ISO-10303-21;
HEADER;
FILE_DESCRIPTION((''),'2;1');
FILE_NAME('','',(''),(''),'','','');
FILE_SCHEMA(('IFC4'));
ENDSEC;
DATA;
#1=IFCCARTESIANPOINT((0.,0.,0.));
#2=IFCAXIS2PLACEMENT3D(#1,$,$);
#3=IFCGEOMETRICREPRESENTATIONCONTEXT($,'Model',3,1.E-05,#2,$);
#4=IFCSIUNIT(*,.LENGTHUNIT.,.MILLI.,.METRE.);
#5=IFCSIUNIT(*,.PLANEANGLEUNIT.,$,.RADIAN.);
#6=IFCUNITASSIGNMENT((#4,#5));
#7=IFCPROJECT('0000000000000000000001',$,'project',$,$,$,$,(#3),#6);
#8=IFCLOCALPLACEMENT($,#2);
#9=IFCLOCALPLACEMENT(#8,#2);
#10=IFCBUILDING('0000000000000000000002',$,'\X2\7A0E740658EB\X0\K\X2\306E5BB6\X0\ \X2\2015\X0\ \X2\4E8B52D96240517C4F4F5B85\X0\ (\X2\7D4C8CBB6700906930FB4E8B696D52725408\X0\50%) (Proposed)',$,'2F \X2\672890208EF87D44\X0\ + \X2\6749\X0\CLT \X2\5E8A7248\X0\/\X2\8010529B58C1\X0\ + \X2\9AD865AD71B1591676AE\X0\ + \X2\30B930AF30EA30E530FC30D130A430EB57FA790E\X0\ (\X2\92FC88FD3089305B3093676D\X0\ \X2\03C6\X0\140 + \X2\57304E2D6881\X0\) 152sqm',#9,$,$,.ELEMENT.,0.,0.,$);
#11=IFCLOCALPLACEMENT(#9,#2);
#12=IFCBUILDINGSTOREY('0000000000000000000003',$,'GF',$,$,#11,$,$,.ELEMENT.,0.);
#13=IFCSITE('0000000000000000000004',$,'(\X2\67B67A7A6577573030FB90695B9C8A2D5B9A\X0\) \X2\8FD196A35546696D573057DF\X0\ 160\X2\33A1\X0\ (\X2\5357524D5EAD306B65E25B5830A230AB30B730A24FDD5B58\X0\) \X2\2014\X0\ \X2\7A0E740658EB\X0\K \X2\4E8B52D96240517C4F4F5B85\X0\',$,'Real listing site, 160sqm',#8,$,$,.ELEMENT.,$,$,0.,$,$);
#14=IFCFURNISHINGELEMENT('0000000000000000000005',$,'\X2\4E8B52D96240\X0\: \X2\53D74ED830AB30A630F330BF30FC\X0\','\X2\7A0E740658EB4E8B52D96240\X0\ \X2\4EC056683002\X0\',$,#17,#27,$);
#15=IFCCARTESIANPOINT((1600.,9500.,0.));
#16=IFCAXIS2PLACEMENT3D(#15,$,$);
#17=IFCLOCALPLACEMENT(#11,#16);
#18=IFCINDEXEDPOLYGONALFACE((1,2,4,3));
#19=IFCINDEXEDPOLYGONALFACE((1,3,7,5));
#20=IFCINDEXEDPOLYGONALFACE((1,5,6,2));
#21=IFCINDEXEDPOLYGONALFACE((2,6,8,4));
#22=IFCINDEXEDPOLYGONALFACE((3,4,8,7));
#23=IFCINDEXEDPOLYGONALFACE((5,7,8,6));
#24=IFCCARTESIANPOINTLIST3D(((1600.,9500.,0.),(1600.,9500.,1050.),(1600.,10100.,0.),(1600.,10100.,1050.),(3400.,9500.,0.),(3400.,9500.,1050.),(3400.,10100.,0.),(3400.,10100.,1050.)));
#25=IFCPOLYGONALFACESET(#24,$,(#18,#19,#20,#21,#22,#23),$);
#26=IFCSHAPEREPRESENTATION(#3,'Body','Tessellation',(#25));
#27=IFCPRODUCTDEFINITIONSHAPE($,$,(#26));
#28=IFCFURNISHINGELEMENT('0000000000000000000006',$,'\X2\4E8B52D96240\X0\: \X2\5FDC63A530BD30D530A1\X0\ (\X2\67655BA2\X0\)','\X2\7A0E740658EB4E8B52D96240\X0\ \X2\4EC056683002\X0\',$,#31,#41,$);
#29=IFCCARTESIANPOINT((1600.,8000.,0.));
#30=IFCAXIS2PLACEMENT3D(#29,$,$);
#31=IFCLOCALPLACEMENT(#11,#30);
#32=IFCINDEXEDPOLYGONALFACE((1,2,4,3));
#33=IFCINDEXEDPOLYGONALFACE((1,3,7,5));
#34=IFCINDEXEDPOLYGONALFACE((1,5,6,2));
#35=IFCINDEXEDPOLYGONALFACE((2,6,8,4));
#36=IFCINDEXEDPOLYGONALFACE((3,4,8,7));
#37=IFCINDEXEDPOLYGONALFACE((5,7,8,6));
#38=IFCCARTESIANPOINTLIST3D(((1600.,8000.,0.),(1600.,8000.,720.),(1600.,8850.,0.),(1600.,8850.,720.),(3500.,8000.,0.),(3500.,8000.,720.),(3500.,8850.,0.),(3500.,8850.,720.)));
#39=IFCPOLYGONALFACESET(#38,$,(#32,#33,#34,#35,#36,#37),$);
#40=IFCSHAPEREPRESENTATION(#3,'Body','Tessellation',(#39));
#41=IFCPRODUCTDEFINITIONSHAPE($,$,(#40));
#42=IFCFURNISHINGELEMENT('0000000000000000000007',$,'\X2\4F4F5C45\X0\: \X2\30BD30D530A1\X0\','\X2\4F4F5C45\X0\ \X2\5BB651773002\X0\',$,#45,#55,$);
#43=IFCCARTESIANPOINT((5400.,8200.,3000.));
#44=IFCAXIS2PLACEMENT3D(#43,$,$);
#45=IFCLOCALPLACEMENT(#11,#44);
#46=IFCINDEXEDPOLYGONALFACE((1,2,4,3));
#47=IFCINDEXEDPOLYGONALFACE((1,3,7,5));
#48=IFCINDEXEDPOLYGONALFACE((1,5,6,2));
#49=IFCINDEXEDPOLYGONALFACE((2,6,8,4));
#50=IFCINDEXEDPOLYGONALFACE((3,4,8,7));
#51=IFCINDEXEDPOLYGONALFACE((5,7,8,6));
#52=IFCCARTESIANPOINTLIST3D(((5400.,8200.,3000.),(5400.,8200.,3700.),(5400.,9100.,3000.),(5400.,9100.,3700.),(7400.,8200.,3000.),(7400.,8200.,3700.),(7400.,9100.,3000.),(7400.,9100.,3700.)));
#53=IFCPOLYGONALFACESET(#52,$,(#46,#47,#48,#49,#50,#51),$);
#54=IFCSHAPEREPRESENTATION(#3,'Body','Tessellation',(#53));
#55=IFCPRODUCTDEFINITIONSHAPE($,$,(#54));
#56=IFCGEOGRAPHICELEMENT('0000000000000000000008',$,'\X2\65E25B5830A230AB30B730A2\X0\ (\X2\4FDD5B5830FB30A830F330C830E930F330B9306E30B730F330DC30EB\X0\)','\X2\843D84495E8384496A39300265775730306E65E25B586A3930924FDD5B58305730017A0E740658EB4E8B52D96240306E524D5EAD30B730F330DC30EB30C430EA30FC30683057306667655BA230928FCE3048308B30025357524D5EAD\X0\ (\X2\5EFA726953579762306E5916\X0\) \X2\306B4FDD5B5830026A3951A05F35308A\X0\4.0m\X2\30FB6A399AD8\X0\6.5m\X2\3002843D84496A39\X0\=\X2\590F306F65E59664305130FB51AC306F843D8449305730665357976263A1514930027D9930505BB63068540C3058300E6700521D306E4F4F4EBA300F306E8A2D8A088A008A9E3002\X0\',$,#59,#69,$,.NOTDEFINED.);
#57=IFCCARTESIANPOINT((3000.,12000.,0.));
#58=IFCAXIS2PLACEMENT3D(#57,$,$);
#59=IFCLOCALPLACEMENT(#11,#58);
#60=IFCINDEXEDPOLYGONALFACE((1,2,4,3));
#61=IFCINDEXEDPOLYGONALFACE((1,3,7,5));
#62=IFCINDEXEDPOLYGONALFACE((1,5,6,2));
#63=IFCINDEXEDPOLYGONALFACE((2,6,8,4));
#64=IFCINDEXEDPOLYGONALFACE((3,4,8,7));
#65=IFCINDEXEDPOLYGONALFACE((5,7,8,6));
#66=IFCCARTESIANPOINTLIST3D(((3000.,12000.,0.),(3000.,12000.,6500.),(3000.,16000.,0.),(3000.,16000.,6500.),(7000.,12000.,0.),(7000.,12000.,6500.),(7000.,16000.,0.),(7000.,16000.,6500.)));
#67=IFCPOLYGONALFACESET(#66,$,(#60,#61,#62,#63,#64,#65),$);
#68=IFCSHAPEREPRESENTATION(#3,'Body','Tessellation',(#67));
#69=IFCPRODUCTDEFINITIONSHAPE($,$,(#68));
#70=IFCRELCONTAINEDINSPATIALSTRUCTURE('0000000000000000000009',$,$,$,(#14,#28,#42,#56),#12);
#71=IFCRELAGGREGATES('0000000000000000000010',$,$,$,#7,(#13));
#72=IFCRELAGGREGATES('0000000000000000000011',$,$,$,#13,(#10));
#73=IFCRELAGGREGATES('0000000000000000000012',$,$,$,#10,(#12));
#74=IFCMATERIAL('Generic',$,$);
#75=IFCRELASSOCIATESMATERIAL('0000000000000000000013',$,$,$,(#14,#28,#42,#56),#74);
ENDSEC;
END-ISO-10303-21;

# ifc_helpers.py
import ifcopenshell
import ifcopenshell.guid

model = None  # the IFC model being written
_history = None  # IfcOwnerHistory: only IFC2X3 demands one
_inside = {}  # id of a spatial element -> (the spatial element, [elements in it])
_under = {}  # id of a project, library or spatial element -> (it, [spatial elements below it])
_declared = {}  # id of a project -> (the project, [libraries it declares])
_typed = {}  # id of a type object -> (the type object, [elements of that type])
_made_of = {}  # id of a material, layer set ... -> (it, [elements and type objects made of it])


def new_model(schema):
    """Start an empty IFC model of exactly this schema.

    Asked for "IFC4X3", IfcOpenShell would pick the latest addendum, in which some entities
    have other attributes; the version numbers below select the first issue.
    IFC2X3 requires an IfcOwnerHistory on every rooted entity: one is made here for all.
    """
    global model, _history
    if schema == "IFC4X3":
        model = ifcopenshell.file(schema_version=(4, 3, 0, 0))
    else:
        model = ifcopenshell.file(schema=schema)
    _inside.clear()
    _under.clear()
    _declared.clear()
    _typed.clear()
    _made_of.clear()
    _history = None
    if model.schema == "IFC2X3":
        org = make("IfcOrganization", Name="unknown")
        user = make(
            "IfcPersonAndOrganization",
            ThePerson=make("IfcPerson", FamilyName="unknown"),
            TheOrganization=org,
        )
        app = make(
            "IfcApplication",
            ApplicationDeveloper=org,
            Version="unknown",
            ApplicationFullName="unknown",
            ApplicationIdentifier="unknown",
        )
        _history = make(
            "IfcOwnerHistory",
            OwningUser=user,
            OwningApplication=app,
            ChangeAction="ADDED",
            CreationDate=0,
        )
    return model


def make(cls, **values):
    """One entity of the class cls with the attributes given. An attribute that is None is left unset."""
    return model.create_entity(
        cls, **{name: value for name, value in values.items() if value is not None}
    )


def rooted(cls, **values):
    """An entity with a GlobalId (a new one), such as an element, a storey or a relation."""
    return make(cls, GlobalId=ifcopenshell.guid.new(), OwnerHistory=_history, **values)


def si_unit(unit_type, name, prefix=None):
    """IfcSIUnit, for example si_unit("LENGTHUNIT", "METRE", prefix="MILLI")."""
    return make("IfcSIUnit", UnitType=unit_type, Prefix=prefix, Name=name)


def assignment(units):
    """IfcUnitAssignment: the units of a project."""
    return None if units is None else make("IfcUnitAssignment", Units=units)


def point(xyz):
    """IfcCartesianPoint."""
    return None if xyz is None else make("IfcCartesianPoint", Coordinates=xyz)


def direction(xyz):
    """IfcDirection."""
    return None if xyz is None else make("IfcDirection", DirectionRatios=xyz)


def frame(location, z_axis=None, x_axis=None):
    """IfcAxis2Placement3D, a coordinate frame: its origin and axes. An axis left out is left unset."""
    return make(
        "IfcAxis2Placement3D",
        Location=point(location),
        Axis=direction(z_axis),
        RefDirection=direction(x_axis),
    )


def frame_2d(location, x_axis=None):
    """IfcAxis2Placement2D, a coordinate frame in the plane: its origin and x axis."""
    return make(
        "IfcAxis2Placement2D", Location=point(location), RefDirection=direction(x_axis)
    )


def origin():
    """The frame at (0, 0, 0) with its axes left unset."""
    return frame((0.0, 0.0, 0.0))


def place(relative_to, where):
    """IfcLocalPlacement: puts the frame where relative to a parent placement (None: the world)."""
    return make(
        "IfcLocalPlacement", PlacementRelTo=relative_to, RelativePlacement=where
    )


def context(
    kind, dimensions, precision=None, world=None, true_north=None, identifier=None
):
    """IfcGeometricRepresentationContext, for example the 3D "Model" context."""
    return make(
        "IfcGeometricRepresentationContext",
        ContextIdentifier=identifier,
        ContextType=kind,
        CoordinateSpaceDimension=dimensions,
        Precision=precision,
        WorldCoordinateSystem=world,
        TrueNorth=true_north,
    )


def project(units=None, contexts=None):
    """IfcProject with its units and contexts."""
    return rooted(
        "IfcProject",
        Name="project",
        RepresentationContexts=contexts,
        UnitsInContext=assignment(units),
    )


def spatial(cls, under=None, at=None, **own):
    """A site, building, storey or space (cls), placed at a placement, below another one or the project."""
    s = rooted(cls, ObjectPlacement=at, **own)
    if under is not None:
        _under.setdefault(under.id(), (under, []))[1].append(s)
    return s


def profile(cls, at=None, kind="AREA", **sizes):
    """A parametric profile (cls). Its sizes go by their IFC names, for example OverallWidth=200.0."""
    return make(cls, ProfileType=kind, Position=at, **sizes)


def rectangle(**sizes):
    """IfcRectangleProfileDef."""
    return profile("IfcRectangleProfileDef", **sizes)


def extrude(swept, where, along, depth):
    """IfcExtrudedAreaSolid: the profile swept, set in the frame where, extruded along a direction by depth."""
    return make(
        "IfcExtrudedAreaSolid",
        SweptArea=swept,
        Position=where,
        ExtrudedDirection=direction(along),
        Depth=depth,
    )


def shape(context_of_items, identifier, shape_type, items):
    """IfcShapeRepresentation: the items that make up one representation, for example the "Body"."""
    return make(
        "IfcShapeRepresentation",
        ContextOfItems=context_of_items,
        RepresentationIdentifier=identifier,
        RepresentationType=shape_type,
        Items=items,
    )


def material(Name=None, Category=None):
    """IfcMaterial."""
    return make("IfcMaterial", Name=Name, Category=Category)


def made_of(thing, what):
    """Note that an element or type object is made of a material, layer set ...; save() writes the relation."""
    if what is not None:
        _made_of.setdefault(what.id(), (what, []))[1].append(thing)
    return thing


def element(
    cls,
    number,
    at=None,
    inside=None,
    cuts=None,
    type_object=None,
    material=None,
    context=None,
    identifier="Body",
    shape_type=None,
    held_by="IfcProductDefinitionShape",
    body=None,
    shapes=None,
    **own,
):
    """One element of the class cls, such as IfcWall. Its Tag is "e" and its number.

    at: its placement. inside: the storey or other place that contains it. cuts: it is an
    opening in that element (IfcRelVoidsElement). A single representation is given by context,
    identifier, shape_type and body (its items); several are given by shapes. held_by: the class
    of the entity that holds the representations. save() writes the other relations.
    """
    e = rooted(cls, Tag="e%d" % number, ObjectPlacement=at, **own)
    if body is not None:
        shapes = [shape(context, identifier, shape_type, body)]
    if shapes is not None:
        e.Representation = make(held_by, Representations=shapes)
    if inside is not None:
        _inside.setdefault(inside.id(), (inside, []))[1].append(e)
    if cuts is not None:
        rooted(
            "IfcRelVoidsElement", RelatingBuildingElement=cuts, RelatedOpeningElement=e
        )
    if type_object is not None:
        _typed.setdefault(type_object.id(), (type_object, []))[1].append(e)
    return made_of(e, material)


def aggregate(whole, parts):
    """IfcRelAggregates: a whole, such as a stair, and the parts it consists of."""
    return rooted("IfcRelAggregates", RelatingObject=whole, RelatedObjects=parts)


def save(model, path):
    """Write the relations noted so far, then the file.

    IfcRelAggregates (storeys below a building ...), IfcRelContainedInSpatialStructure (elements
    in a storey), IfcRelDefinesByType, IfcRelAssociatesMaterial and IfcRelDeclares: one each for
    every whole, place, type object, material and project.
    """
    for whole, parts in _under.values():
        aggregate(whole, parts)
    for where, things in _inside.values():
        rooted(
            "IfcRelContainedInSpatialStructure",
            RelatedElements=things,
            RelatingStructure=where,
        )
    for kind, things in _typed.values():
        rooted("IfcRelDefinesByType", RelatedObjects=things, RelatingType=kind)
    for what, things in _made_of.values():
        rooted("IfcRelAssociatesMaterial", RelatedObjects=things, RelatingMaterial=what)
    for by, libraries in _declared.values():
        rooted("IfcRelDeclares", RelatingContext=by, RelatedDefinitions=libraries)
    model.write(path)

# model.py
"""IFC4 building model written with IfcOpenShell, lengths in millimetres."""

from ifc_helpers import new_model, si_unit, frame, frame_2d, origin, place, context, project, spatial, rectangle, extrude, material, element, save


model = new_model("IFC4")

# Units and contexts
model_context = context("Model", 3, precision=1e-05, world=origin())
ifc_project = project(units=[si_unit("LENGTHUNIT", "METRE", prefix="MILLI"), si_unit("PLANEANGLEUNIT", "RADIAN")], contexts=[model_context])

# Site, building, storey
site_placement = place(None, origin())
site = spatial("IfcSite", under=ifc_project, at=site_placement, Name="(架空敷地・適宜設定) 近隣商業地域 160㎡ (南前庭に既存アカシア保存) — 税理士K 事務所兼住宅", ObjectType="Real listing site, 160sqm", CompositionType="ELEMENT", RefElevation=0.0)
building_placement = place(site_placement, origin())
building = spatial("IfcBuilding", under=site, at=building_placement, Name="税理士Kの家 ― 事務所兼住宅 (経費最適・事業割合50%) (Proposed)", ObjectType="2F 木造軸組 + 杉CLT 床版/耐力壁 + 高断熱外皮 + スクリューパイル基礎 (鋼製らせん杭 φ140 + 地中梁) 152sqm", CompositionType="ELEMENT", ElevationOfRefHeight=0.0, ElevationOfTerrain=0.0)
storey_placement = place(building_placement, origin())
storey = spatial("IfcBuildingStorey", under=building, at=storey_placement, Name="GF", CompositionType="ELEMENT", Elevation=0.0)

# Shared definitions
ifc_material = material(Name="Generic")

# Furnishing elements
furnishing_1_placement = place(storey_placement, frame((1600.0, 9500.0, 0.0)))
element("IfcFurnishingElement", 1, at=furnishing_1_placement, inside=storey, material=ifc_material, Name="事務所: 受付カウンター", Description="税理士事務所 什器。", context=model_context, shape_type="SweptSolid", body=[
    extrude(rectangle(XDim=1800.0, YDim=600.0, at=frame_2d((900.0, 300.0))), frame((1600.0, 9500.0, 0.0)), (0.0, 0.0, 1.0), 1050.0),
])
furnishing_2_placement = place(storey_placement, frame((1600.0, 8000.0, 0.0)))
element("IfcFurnishingElement", 2, at=furnishing_2_placement, inside=storey, material=ifc_material, Name="事務所: 応接ソファ (来客)", Description="税理士事務所 什器。", context=model_context, shape_type="SweptSolid", body=[
    extrude(rectangle(XDim=1900.0, YDim=850.0, at=frame_2d((950.0, 425.0))), frame((1600.0, 8000.0, 0.0)), (0.0, 0.0, 1.0), 720.0),
])
furnishing_3_placement = place(storey_placement, frame((5400.0, 8200.0, 3000.0)))
element("IfcFurnishingElement", 3, at=furnishing_3_placement, inside=storey, material=ifc_material, Name="住居: ソファ", Description="住居 家具。", context=model_context, shape_type="SweptSolid", body=[
    extrude(rectangle(XDim=2000.0, YDim=900.0, at=frame_2d((1000.0, 450.0))), frame((5400.0, 8200.0, 3000.0)), (0.0, 0.0, 1.0), 700.0),
])

# Geographic element
geographic_element_placement = place(storey_placement, frame((3000.0, 12000.0, 0.0)))
element("IfcGeographicElement", 4, at=geographic_element_placement, inside=storey, material=ifc_material, Name="既存アカシア (保存・エントランスのシンボル)", Description="落葉広葉樹。敷地の既存樹を保存し、税理士事務所の前庭シンボルツリーとして来客を迎える。南前庭 (建物南面の外) に保存。樹冠張り4.0m・樹高6.5m。落葉樹=夏は日除け・冬は落葉して南面採光。継ぐ家と同じ『最初の住人』の設計言語。", PredefinedType="NOTDEFINED", context=model_context, shape_type="SweptSolid", body=[
    extrude(rectangle(XDim=4000.0, YDim=4000.0, at=frame_2d((2000.0, 2000.0))), frame((3000.0, 12000.0, 0.0)), (0.0, 0.0, 1.0), 6500.0),
])

save(model, "model.ifc")
